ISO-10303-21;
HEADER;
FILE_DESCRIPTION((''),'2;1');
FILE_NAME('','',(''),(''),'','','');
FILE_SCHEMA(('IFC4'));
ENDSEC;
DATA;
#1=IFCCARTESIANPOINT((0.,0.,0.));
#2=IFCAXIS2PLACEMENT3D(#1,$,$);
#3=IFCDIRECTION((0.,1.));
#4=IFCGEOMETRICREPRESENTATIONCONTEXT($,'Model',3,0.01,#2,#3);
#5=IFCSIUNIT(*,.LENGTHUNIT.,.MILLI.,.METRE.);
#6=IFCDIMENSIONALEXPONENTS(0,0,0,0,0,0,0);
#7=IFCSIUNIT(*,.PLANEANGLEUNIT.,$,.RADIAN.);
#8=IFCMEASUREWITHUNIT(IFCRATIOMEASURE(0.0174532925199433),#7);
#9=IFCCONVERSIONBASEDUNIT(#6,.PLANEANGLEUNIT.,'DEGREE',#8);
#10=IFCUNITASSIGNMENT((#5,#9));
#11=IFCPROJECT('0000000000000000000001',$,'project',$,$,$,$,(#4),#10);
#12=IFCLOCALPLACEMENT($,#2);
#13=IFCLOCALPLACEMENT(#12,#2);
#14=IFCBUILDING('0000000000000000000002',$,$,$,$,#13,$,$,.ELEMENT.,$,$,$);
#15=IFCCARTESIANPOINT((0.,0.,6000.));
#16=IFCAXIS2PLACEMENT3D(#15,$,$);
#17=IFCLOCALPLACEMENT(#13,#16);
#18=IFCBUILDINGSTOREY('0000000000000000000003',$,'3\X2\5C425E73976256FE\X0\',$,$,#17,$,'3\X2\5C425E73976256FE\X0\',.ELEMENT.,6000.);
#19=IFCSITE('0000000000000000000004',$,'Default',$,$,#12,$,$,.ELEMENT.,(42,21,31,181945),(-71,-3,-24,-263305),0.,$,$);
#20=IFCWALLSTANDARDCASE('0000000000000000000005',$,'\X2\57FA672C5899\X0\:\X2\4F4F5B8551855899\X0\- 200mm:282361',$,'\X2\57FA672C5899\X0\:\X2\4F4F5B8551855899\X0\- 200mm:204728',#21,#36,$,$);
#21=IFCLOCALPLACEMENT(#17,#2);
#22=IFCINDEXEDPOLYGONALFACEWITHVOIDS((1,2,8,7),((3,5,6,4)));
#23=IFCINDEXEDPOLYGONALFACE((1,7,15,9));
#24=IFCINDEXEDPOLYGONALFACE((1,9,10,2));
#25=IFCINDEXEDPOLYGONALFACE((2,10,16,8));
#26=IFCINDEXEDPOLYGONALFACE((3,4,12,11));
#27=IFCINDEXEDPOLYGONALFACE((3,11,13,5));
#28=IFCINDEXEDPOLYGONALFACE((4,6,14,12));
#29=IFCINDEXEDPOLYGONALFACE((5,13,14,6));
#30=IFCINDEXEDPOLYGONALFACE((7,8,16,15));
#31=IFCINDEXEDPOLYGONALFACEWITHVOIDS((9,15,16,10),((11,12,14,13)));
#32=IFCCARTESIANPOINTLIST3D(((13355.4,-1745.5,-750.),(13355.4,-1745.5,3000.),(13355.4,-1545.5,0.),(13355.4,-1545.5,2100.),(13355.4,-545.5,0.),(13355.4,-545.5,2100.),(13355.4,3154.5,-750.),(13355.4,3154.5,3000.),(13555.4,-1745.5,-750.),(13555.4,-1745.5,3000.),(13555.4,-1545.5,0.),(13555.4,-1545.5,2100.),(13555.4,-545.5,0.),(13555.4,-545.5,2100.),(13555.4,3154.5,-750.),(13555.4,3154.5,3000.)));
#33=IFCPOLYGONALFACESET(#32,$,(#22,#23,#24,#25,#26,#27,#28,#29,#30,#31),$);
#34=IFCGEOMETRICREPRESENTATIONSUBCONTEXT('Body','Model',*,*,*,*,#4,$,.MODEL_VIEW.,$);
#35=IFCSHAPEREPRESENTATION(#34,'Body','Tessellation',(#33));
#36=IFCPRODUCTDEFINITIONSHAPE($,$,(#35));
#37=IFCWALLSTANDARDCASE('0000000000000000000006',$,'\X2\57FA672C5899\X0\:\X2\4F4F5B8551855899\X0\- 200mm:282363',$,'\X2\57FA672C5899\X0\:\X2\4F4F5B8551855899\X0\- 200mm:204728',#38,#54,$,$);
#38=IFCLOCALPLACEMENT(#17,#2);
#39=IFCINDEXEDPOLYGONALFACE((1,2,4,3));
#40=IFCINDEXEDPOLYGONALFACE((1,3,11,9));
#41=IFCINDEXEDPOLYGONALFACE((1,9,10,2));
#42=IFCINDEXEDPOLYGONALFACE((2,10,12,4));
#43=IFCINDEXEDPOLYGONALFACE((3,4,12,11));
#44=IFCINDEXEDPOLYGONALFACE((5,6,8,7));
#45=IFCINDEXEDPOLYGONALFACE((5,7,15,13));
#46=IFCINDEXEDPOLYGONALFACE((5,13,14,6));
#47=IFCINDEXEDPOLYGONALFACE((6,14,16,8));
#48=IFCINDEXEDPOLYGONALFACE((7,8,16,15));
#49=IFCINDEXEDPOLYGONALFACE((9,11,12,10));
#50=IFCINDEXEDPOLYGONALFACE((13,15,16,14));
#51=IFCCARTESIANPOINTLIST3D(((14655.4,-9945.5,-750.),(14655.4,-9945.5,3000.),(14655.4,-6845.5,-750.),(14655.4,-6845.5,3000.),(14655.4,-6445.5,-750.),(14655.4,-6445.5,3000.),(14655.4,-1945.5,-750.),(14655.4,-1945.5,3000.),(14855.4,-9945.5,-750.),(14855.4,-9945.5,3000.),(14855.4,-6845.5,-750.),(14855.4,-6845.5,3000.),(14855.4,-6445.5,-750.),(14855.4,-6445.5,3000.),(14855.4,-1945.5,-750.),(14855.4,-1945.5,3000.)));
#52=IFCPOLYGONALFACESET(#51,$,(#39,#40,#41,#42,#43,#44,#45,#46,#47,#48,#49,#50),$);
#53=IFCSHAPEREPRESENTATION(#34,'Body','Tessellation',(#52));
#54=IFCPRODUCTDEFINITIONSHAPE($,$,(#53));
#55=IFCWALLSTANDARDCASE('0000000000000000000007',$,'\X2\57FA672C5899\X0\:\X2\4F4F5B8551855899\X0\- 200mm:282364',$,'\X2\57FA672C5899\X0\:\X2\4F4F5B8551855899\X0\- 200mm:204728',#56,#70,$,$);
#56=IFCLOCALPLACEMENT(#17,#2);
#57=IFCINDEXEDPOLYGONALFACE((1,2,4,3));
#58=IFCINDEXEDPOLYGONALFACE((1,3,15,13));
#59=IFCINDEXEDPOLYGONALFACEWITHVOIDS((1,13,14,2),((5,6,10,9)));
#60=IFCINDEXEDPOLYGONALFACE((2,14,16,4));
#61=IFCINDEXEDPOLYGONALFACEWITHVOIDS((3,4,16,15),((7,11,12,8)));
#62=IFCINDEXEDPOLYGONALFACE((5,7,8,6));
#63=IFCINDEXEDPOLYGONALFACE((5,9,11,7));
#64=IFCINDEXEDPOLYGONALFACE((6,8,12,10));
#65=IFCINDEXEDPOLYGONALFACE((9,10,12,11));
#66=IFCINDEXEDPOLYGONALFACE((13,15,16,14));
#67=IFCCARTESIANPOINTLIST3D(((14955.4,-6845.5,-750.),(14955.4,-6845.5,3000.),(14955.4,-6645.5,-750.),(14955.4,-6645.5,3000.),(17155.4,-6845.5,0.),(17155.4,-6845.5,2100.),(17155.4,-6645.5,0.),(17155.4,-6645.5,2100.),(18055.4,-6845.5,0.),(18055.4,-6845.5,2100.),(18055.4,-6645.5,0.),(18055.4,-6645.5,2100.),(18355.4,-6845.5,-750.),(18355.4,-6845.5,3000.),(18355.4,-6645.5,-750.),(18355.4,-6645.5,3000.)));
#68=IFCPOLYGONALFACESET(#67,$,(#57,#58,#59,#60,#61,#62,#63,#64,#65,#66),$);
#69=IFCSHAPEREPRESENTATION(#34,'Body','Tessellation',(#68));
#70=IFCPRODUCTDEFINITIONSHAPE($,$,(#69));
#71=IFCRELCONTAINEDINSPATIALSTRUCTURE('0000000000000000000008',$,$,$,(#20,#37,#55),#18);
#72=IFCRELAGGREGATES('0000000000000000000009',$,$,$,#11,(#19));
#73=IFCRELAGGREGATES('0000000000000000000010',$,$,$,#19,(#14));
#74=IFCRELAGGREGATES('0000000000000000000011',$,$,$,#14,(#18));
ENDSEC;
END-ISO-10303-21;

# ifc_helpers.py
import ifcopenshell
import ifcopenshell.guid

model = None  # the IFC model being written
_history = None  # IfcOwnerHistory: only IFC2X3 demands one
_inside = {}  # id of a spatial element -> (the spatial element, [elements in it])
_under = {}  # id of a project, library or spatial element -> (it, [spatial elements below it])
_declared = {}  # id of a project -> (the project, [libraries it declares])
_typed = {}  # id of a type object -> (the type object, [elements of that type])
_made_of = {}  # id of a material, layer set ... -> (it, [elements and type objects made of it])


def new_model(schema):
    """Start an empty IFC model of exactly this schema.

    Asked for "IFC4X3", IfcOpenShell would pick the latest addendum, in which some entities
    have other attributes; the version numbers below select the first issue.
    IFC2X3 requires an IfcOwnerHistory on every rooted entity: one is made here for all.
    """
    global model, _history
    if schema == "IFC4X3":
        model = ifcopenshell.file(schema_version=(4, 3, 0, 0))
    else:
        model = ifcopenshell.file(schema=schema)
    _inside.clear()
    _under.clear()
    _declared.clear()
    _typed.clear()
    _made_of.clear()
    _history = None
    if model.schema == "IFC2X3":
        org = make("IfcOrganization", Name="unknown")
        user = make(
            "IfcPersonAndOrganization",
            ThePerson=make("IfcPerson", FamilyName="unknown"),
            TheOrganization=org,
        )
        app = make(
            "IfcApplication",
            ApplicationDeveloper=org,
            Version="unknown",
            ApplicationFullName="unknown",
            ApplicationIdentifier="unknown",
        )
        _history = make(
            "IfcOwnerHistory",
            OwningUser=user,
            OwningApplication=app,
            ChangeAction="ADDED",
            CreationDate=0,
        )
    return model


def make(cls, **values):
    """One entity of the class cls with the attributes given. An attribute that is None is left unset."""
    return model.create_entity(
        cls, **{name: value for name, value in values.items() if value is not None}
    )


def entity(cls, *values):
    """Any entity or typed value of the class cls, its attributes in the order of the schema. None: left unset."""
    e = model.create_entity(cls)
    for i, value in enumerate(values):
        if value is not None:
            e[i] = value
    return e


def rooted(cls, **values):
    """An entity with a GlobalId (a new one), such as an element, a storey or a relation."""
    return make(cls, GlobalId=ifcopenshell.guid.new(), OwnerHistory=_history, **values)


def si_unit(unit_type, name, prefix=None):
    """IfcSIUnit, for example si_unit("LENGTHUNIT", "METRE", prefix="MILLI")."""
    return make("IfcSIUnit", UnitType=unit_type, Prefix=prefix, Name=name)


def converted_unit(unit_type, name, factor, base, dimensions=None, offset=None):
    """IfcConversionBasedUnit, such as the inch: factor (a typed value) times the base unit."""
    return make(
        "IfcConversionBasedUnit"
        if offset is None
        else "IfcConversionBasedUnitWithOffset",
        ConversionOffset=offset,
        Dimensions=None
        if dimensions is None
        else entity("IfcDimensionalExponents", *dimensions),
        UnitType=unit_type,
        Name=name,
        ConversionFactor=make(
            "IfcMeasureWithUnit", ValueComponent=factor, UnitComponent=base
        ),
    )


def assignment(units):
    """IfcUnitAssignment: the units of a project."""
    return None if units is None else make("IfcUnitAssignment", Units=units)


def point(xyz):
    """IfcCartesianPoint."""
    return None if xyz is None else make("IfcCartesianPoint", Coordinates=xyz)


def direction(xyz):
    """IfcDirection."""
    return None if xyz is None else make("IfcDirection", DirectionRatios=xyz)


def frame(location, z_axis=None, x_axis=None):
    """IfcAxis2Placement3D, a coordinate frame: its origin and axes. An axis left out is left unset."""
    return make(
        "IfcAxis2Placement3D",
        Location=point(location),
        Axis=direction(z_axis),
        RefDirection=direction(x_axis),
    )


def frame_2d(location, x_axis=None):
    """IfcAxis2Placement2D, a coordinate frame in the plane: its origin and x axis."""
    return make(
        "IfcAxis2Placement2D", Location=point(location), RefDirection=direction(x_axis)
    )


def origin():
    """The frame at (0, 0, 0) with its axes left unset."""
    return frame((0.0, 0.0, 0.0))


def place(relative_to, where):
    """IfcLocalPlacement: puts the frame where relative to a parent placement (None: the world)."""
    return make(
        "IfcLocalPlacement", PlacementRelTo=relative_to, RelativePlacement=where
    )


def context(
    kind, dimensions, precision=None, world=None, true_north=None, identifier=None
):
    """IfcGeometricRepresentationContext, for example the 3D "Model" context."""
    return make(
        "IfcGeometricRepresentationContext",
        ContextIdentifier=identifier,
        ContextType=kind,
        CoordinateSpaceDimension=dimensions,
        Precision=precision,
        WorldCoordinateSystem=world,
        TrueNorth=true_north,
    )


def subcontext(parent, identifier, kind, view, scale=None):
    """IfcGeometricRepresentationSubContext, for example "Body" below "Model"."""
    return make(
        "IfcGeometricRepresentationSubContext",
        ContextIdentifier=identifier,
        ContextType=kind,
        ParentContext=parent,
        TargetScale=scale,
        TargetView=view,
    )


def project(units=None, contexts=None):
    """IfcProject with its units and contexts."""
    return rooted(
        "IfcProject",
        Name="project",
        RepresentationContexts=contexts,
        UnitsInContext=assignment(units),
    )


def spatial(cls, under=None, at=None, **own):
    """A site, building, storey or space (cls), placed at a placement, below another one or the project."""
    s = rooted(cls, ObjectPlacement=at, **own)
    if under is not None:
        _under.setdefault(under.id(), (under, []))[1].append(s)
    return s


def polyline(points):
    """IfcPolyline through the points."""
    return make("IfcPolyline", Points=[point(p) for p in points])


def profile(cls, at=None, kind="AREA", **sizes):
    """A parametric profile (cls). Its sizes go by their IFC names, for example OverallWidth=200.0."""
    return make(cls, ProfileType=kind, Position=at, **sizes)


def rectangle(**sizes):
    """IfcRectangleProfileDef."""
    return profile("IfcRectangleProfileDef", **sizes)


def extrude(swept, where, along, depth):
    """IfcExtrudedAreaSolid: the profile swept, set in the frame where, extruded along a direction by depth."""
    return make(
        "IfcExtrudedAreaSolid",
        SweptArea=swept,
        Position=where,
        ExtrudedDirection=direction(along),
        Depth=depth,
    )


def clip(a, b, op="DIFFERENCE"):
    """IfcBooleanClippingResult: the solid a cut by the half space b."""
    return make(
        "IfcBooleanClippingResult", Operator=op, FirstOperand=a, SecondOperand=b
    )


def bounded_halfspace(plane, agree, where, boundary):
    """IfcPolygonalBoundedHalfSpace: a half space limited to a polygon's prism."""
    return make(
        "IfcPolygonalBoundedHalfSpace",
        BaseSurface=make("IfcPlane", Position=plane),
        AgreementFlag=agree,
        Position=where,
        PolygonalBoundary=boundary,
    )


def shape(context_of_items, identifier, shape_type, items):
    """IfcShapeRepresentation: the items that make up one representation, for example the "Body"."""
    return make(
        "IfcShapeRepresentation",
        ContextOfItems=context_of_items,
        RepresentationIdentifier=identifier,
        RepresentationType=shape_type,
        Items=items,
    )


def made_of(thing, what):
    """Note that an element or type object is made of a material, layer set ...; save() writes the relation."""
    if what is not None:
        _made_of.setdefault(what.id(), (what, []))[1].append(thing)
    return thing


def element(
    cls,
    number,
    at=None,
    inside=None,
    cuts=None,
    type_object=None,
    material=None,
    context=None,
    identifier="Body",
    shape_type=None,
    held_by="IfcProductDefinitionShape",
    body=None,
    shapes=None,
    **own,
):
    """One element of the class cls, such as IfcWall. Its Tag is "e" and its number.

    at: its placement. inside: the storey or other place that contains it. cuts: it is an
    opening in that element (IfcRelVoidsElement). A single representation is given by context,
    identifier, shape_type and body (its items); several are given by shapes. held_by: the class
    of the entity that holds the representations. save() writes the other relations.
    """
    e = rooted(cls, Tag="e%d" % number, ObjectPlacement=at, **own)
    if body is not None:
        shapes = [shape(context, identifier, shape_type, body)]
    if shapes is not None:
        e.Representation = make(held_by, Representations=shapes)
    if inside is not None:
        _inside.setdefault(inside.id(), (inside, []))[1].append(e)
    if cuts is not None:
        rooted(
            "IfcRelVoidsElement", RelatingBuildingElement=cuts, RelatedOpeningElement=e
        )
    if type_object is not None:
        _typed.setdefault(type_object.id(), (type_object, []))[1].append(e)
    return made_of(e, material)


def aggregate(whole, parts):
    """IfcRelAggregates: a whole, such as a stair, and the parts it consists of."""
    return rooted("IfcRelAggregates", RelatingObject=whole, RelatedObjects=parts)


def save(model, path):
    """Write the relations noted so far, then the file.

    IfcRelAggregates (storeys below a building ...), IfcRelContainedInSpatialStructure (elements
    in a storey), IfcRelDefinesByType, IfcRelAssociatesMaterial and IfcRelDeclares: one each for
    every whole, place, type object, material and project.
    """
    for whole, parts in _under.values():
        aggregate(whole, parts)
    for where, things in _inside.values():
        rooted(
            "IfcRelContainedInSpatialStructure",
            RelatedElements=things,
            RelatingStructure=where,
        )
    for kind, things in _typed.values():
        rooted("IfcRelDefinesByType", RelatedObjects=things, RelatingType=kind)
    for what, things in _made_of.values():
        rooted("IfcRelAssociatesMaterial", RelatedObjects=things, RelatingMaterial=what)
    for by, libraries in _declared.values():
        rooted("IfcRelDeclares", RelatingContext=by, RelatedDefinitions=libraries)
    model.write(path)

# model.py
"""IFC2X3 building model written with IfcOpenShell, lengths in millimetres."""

from ifc_helpers import new_model, entity, si_unit, converted_unit, direction, frame, frame_2d, origin, place, context, subcontext, project, spatial, polyline, rectangle, extrude, clip, bounded_halfspace, element, save


model = new_model("IFC2X3")

# Units and contexts
model_context = context("Model", 3, precision=0.01, world=origin(), true_north=direction((0.0, 1.0)))
body_context = subcontext(model_context, "Body", "Model", "MODEL_VIEW")
ifc_project = project(units=[si_unit("LENGTHUNIT", "METRE", prefix="MILLI"), converted_unit("PLANEANGLEUNIT", "DEGREE", entity("IfcRatioMeasure", 0.0174532925199433), si_unit("PLANEANGLEUNIT", "RADIAN"), dimensions=[0, 0, 0, 0, 0, 0, 0])], contexts=[model_context])

# Site, building, storey
site_placement = place(None, origin())
site = spatial("IfcSite", under=ifc_project, at=site_placement, Name="Default", CompositionType="ELEMENT", RefLatitude=(42, 21, 31, 181945), RefLongitude=(-71, -3, -24, -263305), RefElevation=0.0)
building_placement = place(site_placement, origin())
building = spatial("IfcBuilding", under=site, at=building_placement, CompositionType="ELEMENT")
storey_placement = place(building_placement, frame((0.0, 0.0, 6000.0)))
storey = spatial("IfcBuildingStorey", under=building, at=storey_placement, Name="3层平面图", LongName="3层平面图", CompositionType="ELEMENT", Elevation=6000.0)

# Walls, openings
wall_1_placement = place(storey_placement, frame((13455.4, -1745.5, -750.0), z_axis=(0.0, 0.0, 1.0), x_axis=(0.0, 1.0, 0.0)))
wall_1 = element("IfcWallStandardCase", 1, at=wall_1_placement, inside=storey, Name="基本墙:住宅内墙- 200mm:282361", ObjectType="基本墙:住宅内墙- 200mm:204728", context=body_context, shape_type="SweptSolid", body=[
    extrude(rectangle(XDim=4900.0, YDim=200.0, at=frame_2d((2450.0, 0.0), x_axis=(-1.0, 0.0))), origin(), (0.0, 0.0, 1.0), 3750.0),
])
opening_1_placement = place(wall_1_placement, frame((1200.0, 100.0, 750.0)))
element("IfcOpeningElement", 2, at=opening_1_placement, cuts=wall_1, ObjectType="Opening", context=body_context, shape_type="SweptSolid", body=[
    extrude(rectangle(XDim=2100.0, YDim=1000.0, at=frame_2d((1050.0, 500.0), x_axis=(1.0, 0.0))), frame((0.0, 0.0, 0.0), z_axis=(0.0, -1.0, 0.0), x_axis=(0.0, 0.0, 1.0)), (0.0, 0.0, 1.0), 200.0),
])
wall_2_placement = place(storey_placement, frame((14755.4, -1945.5, -750.0), z_axis=(0.0, 0.0, 1.0), x_axis=(0.0, -1.0, 0.0)))
wall_2 = element("IfcWallStandardCase", 3, at=wall_2_placement, inside=storey, Name="基本墙:住宅内墙- 200mm:282363", ObjectType="基本墙:住宅内墙- 200mm:204728", context=body_context, shape_type="Clipping", body=[
    clip(extrude(rectangle(XDim=8000.0, YDim=200.0, at=frame_2d((4000.0, 0.0), x_axis=(-1.0, 0.0))), origin(), (0.0, 0.0, 1.0), 3750.0), bounded_halfspace(frame((8000.0, -100.0, 3750.0), z_axis=(1.0, 0.0, 0.0), x_axis=(0.0, 0.0, -1.0)), False, frame((8000.0, -100.0, 3750.0), z_axis=(1.0, 0.0, 0.0), x_axis=(0.0, 0.0, -1.0)), polyline([(0.0, 0.0), (3750.0, 0.0), (3750.0, 200.0), (0.0, 200.0), (0.0, 0.0)]))),
])
opening_2_placement = place(storey_placement, frame((14755.4, -1945.5, -750.0), z_axis=(0.0, 0.0, 1.0), x_axis=(0.0, -1.0, 0.0)))
element("IfcOpeningElement", 4, at=opening_2_placement, cuts=wall_2, ObjectType="Opening", context=body_context, shape_type="SweptSolid", body=[
    extrude(rectangle(XDim=3750.0, YDim=200.0, at=frame_2d((0.0, 0.0), x_axis=(1.0, 0.0))), frame((4900.0, 0.0, 1875.0), z_axis=(-1.0, 0.0, 0.0), x_axis=(0.0, 0.0, 1.0)), (0.0, 0.0, 1.0), 400.0),
])
wall_3_placement = place(storey_placement, frame((18355.4, -6745.5, -750.0), z_axis=(0.0, 0.0, 1.0), x_axis=(-1.0, 0.0, 0.0)))
wall_3 = element("IfcWallStandardCase", 5, at=wall_3_placement, inside=storey, Name="基本墙:住宅内墙- 200mm:282364", ObjectType="基本墙:住宅内墙- 200mm:204728", context=body_context, shape_type="Clipping", body=[
    clip(extrude(rectangle(XDim=3400.0, YDim=200.0, at=frame_2d((1700.0, 0.0), x_axis=(-1.0, 0.0))), origin(), (0.0, 0.0, 1.0), 3750.0), bounded_halfspace(frame((3400.0, -100.0, 3750.0), z_axis=(1.0, 0.0, 0.0), x_axis=(0.0, 0.0, -1.0)), False, frame((3400.0, -100.0, 3750.0), z_axis=(1.0, 0.0, 0.0), x_axis=(0.0, 0.0, -1.0)), polyline([(0.0, 0.0), (3750.0, 0.0), (3750.0, 200.0), (0.0, 200.0), (0.0, 0.0)]))),
])
opening_3_placement = place(wall_3_placement, origin())
element("IfcOpeningElement", 6, at=opening_3_placement, cuts=wall_3, ObjectType="Opening", context=body_context, shape_type="SweptSolid", body=[
    extrude(rectangle(XDim=2100.0, YDim=900.0, at=frame_2d((0.0, 0.0), x_axis=(1.0, 0.0))), frame((750.0, -1624.0, 1800.0), z_axis=(0.0, 1.0, 0.0), x_axis=(0.0, 0.0, 1.0)), (0.0, 0.0, 1.0), 3048.0),
])

save(model, "model.ifc")
